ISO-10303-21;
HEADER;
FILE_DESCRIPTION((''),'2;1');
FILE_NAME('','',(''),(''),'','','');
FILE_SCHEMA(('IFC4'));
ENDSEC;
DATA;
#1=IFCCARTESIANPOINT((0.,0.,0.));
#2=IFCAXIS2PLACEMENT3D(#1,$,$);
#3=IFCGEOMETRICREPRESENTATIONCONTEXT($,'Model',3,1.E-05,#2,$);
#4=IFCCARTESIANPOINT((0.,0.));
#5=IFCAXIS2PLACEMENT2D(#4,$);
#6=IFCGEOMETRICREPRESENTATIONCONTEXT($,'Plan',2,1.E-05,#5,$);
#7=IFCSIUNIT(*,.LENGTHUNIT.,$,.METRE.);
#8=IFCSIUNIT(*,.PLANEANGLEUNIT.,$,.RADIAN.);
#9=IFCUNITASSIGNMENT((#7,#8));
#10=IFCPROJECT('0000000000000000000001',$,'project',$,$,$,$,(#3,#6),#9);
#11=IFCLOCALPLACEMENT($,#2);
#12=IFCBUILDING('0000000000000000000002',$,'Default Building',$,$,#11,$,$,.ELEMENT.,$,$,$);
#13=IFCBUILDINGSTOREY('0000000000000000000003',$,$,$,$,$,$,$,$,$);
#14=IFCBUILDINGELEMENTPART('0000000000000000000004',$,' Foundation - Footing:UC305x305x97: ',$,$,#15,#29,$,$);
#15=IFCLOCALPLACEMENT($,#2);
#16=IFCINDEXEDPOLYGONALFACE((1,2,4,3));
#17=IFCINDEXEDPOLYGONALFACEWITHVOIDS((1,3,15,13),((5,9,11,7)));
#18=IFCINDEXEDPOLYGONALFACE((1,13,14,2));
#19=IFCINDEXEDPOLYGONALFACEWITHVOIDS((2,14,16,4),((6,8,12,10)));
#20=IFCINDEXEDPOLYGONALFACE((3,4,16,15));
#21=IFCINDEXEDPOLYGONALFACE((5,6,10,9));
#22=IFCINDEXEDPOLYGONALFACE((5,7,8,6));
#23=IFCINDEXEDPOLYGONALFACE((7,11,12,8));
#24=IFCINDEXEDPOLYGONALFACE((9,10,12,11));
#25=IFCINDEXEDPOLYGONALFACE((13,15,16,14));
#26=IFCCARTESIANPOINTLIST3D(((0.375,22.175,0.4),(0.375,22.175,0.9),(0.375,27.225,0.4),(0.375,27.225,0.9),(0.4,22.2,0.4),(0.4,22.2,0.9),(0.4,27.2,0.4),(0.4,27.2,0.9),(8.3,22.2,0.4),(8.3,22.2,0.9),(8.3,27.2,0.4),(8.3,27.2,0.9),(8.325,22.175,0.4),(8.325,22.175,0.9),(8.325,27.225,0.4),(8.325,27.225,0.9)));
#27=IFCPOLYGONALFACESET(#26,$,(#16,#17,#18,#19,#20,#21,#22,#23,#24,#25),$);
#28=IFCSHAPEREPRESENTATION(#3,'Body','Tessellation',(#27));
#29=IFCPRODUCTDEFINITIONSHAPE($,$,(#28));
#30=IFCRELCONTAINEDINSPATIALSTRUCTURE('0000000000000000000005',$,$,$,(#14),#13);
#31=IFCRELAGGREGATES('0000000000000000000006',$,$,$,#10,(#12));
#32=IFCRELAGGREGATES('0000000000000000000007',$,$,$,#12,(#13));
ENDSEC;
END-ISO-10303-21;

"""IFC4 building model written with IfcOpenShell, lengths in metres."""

from ifc_helpers import new_model, si_unit, origin, origin_2d, place, context, project, spatial, polyline, outline, extrude, element, save


model = new_model("IFC4")

# Units and contexts
model_context = context("Model", 3, precision=1e-05, world=origin())
plan_context = context("Plan", 2, precision=1e-05, world=origin_2d())
ifc_project = project(units=[si_unit("LENGTHUNIT", "METRE"), si_unit("PLANEANGLEUNIT", "RADIAN")], contexts=[model_context, plan_context])

# Building, storey
building_placement = place(None, origin())
building = spatial("IfcBuilding", under=ifc_project, at=building_placement, Name="Default Building", CompositionType="ELEMENT")
storey = spatial("IfcBuildingStorey", under=building)

# Building element part, opening
building_element_part_1 = element("IfcBuildingElementPart", 1, inside=storey, Name=" Foundation - Footing:UC305x305x97: ", context=model_context, shape_type="SweptSolid", body=[
    extrude(outline(polyline([(8.325, 27.225, 0.4), (0.375, 27.225, 0.4), (0.375, 22.175, 0.4), (8.325, 22.175, 0.4), (8.325, 27.225, 0.4)])), None, (0.0, 0.0, 1.0), 0.5),
])
element("IfcOpeningElement", 2, inside=storey, cuts=building_element_part_1, context=model_context, shape_type="SweptSolid", body=[
    extrude(outline(polyline([(8.3, 27.2, 0.4), (0.4, 27.2, 0.4), (0.4, 22.2, 0.4), (8.3, 22.2, 0.4), (8.3, 27.2, 0.4)])), None, (0.0, 0.0, 1.0), 0.5),
])

save(model, "model.ifc")
